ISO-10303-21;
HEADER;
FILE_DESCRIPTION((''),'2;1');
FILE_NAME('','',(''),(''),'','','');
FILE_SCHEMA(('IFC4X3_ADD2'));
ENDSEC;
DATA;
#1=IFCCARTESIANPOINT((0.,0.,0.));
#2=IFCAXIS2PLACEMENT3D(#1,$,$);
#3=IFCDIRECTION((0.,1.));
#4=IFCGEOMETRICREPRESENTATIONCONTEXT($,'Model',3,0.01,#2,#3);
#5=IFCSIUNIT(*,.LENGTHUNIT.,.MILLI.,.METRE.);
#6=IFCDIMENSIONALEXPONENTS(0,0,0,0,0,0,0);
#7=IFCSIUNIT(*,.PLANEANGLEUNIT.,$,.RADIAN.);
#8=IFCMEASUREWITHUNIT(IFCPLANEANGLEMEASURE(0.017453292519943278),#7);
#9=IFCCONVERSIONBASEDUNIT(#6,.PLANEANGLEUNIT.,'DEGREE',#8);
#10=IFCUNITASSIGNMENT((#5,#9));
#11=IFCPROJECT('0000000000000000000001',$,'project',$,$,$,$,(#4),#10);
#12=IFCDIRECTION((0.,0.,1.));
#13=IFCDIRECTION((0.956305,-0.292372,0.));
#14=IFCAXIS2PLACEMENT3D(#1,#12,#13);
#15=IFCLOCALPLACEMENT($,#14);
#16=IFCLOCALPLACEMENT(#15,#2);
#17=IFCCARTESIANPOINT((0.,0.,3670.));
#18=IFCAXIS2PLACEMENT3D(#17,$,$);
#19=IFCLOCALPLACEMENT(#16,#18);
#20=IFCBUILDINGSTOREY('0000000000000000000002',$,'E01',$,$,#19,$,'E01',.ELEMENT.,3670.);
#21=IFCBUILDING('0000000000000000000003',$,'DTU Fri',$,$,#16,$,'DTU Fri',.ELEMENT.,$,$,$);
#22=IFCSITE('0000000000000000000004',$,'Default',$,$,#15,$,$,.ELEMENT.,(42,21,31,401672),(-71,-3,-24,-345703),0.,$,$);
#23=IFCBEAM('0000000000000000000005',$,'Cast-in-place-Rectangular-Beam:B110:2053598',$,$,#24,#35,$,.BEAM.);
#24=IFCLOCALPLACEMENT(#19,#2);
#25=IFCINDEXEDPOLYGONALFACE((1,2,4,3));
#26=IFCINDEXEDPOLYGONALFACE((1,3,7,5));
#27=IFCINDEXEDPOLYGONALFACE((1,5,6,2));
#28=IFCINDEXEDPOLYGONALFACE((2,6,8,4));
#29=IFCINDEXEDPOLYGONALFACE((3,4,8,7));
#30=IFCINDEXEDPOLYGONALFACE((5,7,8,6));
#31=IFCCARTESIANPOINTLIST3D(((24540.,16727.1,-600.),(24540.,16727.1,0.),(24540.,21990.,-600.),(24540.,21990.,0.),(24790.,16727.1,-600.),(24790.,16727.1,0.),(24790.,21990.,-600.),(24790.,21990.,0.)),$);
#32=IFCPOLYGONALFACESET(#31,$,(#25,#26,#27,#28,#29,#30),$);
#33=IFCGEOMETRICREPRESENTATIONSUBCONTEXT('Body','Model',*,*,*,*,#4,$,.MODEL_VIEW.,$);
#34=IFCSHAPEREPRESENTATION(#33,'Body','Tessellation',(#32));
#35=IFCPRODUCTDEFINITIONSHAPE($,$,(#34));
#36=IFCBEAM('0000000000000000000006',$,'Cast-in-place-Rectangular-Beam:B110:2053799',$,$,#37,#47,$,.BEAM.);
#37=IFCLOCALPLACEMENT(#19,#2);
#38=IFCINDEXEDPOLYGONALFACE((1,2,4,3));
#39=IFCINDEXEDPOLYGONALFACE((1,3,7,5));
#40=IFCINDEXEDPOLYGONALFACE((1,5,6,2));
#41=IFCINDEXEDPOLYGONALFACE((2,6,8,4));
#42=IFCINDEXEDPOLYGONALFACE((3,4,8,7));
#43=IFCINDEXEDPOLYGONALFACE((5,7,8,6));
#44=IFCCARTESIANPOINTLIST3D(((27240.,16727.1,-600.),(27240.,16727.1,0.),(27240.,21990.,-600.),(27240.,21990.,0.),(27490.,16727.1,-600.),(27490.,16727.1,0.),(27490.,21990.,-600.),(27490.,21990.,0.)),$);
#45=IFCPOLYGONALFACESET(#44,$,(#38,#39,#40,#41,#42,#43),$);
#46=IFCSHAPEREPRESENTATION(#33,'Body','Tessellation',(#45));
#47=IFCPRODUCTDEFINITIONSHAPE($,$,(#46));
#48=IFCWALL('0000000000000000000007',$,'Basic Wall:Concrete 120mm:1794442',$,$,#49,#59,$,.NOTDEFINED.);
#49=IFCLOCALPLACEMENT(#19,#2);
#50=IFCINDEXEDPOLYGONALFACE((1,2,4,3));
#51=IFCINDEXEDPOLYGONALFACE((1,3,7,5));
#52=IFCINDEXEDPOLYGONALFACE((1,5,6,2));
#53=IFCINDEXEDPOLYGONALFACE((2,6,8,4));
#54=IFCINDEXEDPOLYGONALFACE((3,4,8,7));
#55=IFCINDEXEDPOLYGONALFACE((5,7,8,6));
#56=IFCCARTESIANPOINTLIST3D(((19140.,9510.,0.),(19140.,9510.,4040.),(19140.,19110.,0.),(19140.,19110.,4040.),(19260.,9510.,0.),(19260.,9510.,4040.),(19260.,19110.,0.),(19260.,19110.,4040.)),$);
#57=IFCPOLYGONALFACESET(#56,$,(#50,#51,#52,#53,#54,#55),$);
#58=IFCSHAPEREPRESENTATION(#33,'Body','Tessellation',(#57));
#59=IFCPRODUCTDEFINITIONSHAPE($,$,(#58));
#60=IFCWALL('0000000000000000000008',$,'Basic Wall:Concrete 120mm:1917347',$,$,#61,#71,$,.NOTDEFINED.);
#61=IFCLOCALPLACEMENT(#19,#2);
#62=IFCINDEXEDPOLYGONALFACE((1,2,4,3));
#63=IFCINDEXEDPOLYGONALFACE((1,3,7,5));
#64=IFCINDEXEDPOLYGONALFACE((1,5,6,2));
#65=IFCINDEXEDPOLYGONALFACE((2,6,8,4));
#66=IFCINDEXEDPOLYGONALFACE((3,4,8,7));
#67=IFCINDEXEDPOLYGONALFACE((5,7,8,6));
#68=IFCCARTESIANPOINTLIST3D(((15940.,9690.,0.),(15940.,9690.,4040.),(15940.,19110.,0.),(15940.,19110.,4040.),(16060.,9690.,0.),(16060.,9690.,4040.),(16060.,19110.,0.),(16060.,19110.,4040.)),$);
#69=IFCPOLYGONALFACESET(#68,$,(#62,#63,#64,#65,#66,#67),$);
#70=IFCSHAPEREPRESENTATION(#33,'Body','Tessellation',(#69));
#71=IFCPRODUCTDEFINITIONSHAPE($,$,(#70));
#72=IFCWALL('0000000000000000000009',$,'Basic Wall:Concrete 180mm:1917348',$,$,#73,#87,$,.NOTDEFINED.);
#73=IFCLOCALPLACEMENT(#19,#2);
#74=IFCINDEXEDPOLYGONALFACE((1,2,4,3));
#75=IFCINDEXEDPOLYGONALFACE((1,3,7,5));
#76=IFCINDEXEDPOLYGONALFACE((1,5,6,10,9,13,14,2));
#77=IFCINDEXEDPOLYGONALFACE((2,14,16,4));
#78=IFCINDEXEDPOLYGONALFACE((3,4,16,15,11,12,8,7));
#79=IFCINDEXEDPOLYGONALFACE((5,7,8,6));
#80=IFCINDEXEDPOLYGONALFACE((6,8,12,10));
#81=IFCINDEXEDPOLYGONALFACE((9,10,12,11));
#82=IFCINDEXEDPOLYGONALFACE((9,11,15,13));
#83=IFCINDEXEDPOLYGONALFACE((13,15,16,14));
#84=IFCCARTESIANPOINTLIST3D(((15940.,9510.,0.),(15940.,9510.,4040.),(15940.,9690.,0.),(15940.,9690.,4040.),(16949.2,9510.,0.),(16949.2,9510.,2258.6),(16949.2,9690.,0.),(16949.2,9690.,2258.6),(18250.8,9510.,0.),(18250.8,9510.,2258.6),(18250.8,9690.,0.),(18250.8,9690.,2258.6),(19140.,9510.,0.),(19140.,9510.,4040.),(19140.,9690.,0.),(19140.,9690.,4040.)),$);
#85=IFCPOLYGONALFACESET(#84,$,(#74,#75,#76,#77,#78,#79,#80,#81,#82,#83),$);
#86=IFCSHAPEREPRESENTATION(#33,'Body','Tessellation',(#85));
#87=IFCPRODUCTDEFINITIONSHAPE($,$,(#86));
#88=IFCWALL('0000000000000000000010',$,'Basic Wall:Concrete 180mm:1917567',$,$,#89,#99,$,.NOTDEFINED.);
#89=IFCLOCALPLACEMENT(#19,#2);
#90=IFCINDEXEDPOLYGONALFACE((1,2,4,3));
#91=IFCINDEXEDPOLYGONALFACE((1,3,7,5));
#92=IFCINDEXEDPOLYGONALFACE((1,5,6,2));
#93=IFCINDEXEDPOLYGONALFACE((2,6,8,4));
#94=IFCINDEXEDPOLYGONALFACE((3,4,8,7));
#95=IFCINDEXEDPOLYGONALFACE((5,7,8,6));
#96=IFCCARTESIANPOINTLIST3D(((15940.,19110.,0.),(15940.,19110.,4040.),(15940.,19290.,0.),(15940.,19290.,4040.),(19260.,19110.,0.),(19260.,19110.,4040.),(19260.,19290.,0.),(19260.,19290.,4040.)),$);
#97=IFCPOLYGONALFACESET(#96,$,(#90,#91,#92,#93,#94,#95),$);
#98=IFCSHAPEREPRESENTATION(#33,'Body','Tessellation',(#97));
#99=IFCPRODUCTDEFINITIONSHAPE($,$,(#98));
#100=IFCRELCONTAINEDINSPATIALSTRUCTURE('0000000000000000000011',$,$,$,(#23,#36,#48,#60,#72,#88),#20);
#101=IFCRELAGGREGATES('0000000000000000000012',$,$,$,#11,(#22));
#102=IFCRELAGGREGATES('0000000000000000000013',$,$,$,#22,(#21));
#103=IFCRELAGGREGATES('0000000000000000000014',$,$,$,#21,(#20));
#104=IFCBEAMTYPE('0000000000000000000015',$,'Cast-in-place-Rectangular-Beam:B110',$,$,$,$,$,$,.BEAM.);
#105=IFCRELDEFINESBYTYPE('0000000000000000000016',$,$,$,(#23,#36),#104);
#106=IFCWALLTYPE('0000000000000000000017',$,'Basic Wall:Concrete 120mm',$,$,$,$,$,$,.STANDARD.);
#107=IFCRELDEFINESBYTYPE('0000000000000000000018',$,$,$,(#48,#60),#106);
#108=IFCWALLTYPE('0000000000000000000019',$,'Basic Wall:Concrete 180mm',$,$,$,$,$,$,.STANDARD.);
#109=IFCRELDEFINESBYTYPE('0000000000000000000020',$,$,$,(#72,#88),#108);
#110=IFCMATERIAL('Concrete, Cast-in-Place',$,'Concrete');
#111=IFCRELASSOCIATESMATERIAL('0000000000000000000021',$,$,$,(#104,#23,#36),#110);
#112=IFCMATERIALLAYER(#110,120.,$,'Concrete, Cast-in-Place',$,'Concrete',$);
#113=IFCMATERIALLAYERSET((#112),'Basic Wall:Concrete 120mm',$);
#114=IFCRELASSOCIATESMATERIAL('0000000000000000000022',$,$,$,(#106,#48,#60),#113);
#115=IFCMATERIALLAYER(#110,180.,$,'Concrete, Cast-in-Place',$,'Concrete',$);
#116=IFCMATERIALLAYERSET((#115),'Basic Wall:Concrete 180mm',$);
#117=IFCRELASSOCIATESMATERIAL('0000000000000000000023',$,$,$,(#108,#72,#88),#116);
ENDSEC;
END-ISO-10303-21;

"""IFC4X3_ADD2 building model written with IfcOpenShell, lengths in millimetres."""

from ifc_helpers import new_model, entity, si_unit, converted_unit, direction, frame, frame_2d, origin, origin_2d_with_axis, place, context, subcontext, project, spatial, rectangle, extrude, source, transform, mapped, material, layer, layer_set, material_profile, profile_set, profile_usage, type_object, type_shapes, element, save


model = new_model("IFC4X3_ADD2")

# Units and contexts
model_context = context("Model", 3, precision=0.01, world=origin(), true_north=direction((0.0, 1.0)))
body_context = subcontext(model_context, "Body", "Model", "MODEL_VIEW")
ifc_project = project(units=[si_unit("LENGTHUNIT", "METRE", prefix="MILLI"), converted_unit("PLANEANGLEUNIT", "DEGREE", entity("IfcPlaneAngleMeasure", 0.017453292519943278), si_unit("PLANEANGLEUNIT", "RADIAN"), dimensions=[0, 0, 0, 0, 0, 0, 0])], contexts=[model_context])

# Site, building, storey
site_placement = place(None, frame((0.0, 0.0, 0.0), z_axis=(0.0, 0.0, 1.0), x_axis=(0.956305, -0.292372, 0.0)))
site = spatial("IfcSite", under=ifc_project, at=site_placement, Name="Default", CompositionType="ELEMENT", RefLatitude=(42, 21, 31, 401672), RefLongitude=(-71, -3, -24, -345703), RefElevation=0.0)
building_placement = place(site_placement, origin())
building = spatial("IfcBuilding", under=site, at=building_placement, Name="DTU Fri", LongName="DTU Fri", CompositionType="ELEMENT")
storey_placement = place(building_placement, frame((0.0, 0.0, 3670.0)))
storey = spatial("IfcBuildingStorey", under=building, at=storey_placement, Name="E01", LongName="E01", CompositionType="ELEMENT", Elevation=3670.0)

# Beams
ifc_material_1 = material(Name="Concrete, Cast-in-Place", Category="Concrete")
ifc_material_profile_1 = material_profile(ifc_material_1, rectangle(XDim=600.0, YDim=250.0, at=origin_2d_with_axis()), Name="B110")
ifc_profile_set_1 = profile_set([ifc_material_profile_1], Name="B110")
ifc_profile_usage_1 = profile_usage(ifc_profile_set_1, cardinal=8)
beam_type_1 = type_object("IfcBeamType", Name="Cast-in-place-Rectangular-Beam:B110", PredefinedType="BEAM", material=ifc_profile_set_1)
shared_shape_1 = source(origin(), body_context, "Body", "SweptSolid", [
    extrude(rectangle(XDim=600.0, YDim=250.0, at=origin_2d_with_axis()), frame((-2634.0, 0.0, 0.0), z_axis=(1.0, 0.0, 0.0), x_axis=(0.0, 0.0, -1.0)), (0.0, 0.0, 1.0), 5262.9),
])
type_shapes(beam_type_1, [shared_shape_1])
for number, where, z_axis, x_axis, name in (
    (1, (24665.0, 19356.0, -300.0), (0.0, 0.0, 1.0), (0.0, -1.0, 0.0), "Cast-in-place-Rectangular-Beam:B110:2053598"),
    (2, (27365.0, 19356.0, -300.0), (0.0, 0.0, 1.0), (0.0, -1.0, 0.0), "Cast-in-place-Rectangular-Beam:B110:2053799"),
):
    element("IfcBeam", number, at=place(storey_placement, frame(where, z_axis=z_axis, x_axis=x_axis)), inside=storey, type_object=beam_type_1, material=ifc_profile_usage_1, Name=name, PredefinedType="BEAM", context=body_context, shape_type="MappedRepresentation", body=[
        mapped(shared_shape_1, transform((0.0, 0.0, 0.0), scale=1.0)),
    ])

# Walls
ifc_layer_1 = layer(ifc_material_1, 120.0, Name="Concrete, Cast-in-Place", Category="Concrete")
ifc_layer_set_1 = layer_set([ifc_layer_1], Name="Basic Wall:Concrete 120mm")
wall_type_1 = type_object("IfcWallType", Name="Basic Wall:Concrete 120mm", PredefinedType="STANDARD", material=ifc_layer_set_1)
wall_1_placement = place(storey_placement, frame((19200.0, 9510.0, 0.0), z_axis=(0.0, 0.0, 1.0), x_axis=(0.0, 1.0, 0.0)))
element("IfcWall", 3, at=wall_1_placement, inside=storey, type_object=wall_type_1, material=ifc_layer_set_1, Name="Basic Wall:Concrete 120mm:1794442", PredefinedType="NOTDEFINED", context=body_context, shape_type="SweptSolid", body=[
    extrude(rectangle(XDim=9600.0, YDim=120.0, at=frame_2d((4800.0, 0.0), x_axis=(-1.0, 0.0))), origin(), (0.0, 0.0, 1.0), 4040.0),
])
wall_2_placement = place(storey_placement, frame((16000.0, 9690.0, 0.0), z_axis=(0.0, 0.0, 1.0), x_axis=(0.0, 1.0, 0.0)))
element("IfcWall", 4, at=wall_2_placement, inside=storey, type_object=wall_type_1, material=ifc_layer_set_1, Name="Basic Wall:Concrete 120mm:1917347", PredefinedType="NOTDEFINED", context=body_context, shape_type="SweptSolid", body=[
    extrude(rectangle(XDim=9420.0, YDim=120.0, at=frame_2d((4710.0, 0.0), x_axis=(-1.0, 0.0))), origin(), (0.0, 0.0, 1.0), 4040.0),
])

# Wall, opening
ifc_layer_2 = layer(ifc_material_1, 180.0, Name="Concrete, Cast-in-Place", Category="Concrete")
ifc_layer_set_2 = layer_set([ifc_layer_2], Name="Basic Wall:Concrete 180mm")
wall_type_2 = type_object("IfcWallType", Name="Basic Wall:Concrete 180mm", PredefinedType="STANDARD", material=ifc_layer_set_2)
wall_3_placement = place(storey_placement, frame((15940.0, 9600.0, 0.0)))
wall_3 = element("IfcWall", 5, at=wall_3_placement, inside=storey, type_object=wall_type_2, material=ifc_layer_set_2, Name="Basic Wall:Concrete 180mm:1917348", PredefinedType="NOTDEFINED", context=body_context, shape_type="SweptSolid", body=[
    extrude(rectangle(XDim=3200.0, YDim=180.0, at=frame_2d((1600.0, 0.0), x_axis=(-1.0, 0.0))), origin(), (0.0, 0.0, 1.0), 4040.0),
])
opening_placement = place(wall_3_placement, origin())
element("IfcOpeningElement", 6, at=opening_placement, cuts=wall_3, PredefinedType="OPENING", context=body_context, shape_type="SweptSolid", body=[
    extrude(rectangle(XDim=2258.6, YDim=1301.6, at=frame_2d((0.0, 0.0), x_axis=(0.0, 1.0))), frame((1660.0, 90.0, 1129.3), z_axis=(0.0, -1.0, 0.0), x_axis=(1.0, 0.0, 0.0)), (0.0, 0.0, 1.0), 180.0),
])

# Wall
wall_4_placement = place(storey_placement, frame((19260.0, 19200.0, 0.0), z_axis=(0.0, 0.0, 1.0), x_axis=(-1.0, 0.0, 0.0)))
element("IfcWall", 7, at=wall_4_placement, inside=storey, type_object=wall_type_2, material=ifc_layer_set_2, Name="Basic Wall:Concrete 180mm:1917567", PredefinedType="NOTDEFINED", context=body_context, shape_type="SweptSolid", body=[
    extrude(rectangle(XDim=3320.0, YDim=180.0, at=frame_2d((1660.0, 0.0), x_axis=(-1.0, 0.0))), origin(), (0.0, 0.0, 1.0), 4040.0),
])

save(model, "model.ifc")
